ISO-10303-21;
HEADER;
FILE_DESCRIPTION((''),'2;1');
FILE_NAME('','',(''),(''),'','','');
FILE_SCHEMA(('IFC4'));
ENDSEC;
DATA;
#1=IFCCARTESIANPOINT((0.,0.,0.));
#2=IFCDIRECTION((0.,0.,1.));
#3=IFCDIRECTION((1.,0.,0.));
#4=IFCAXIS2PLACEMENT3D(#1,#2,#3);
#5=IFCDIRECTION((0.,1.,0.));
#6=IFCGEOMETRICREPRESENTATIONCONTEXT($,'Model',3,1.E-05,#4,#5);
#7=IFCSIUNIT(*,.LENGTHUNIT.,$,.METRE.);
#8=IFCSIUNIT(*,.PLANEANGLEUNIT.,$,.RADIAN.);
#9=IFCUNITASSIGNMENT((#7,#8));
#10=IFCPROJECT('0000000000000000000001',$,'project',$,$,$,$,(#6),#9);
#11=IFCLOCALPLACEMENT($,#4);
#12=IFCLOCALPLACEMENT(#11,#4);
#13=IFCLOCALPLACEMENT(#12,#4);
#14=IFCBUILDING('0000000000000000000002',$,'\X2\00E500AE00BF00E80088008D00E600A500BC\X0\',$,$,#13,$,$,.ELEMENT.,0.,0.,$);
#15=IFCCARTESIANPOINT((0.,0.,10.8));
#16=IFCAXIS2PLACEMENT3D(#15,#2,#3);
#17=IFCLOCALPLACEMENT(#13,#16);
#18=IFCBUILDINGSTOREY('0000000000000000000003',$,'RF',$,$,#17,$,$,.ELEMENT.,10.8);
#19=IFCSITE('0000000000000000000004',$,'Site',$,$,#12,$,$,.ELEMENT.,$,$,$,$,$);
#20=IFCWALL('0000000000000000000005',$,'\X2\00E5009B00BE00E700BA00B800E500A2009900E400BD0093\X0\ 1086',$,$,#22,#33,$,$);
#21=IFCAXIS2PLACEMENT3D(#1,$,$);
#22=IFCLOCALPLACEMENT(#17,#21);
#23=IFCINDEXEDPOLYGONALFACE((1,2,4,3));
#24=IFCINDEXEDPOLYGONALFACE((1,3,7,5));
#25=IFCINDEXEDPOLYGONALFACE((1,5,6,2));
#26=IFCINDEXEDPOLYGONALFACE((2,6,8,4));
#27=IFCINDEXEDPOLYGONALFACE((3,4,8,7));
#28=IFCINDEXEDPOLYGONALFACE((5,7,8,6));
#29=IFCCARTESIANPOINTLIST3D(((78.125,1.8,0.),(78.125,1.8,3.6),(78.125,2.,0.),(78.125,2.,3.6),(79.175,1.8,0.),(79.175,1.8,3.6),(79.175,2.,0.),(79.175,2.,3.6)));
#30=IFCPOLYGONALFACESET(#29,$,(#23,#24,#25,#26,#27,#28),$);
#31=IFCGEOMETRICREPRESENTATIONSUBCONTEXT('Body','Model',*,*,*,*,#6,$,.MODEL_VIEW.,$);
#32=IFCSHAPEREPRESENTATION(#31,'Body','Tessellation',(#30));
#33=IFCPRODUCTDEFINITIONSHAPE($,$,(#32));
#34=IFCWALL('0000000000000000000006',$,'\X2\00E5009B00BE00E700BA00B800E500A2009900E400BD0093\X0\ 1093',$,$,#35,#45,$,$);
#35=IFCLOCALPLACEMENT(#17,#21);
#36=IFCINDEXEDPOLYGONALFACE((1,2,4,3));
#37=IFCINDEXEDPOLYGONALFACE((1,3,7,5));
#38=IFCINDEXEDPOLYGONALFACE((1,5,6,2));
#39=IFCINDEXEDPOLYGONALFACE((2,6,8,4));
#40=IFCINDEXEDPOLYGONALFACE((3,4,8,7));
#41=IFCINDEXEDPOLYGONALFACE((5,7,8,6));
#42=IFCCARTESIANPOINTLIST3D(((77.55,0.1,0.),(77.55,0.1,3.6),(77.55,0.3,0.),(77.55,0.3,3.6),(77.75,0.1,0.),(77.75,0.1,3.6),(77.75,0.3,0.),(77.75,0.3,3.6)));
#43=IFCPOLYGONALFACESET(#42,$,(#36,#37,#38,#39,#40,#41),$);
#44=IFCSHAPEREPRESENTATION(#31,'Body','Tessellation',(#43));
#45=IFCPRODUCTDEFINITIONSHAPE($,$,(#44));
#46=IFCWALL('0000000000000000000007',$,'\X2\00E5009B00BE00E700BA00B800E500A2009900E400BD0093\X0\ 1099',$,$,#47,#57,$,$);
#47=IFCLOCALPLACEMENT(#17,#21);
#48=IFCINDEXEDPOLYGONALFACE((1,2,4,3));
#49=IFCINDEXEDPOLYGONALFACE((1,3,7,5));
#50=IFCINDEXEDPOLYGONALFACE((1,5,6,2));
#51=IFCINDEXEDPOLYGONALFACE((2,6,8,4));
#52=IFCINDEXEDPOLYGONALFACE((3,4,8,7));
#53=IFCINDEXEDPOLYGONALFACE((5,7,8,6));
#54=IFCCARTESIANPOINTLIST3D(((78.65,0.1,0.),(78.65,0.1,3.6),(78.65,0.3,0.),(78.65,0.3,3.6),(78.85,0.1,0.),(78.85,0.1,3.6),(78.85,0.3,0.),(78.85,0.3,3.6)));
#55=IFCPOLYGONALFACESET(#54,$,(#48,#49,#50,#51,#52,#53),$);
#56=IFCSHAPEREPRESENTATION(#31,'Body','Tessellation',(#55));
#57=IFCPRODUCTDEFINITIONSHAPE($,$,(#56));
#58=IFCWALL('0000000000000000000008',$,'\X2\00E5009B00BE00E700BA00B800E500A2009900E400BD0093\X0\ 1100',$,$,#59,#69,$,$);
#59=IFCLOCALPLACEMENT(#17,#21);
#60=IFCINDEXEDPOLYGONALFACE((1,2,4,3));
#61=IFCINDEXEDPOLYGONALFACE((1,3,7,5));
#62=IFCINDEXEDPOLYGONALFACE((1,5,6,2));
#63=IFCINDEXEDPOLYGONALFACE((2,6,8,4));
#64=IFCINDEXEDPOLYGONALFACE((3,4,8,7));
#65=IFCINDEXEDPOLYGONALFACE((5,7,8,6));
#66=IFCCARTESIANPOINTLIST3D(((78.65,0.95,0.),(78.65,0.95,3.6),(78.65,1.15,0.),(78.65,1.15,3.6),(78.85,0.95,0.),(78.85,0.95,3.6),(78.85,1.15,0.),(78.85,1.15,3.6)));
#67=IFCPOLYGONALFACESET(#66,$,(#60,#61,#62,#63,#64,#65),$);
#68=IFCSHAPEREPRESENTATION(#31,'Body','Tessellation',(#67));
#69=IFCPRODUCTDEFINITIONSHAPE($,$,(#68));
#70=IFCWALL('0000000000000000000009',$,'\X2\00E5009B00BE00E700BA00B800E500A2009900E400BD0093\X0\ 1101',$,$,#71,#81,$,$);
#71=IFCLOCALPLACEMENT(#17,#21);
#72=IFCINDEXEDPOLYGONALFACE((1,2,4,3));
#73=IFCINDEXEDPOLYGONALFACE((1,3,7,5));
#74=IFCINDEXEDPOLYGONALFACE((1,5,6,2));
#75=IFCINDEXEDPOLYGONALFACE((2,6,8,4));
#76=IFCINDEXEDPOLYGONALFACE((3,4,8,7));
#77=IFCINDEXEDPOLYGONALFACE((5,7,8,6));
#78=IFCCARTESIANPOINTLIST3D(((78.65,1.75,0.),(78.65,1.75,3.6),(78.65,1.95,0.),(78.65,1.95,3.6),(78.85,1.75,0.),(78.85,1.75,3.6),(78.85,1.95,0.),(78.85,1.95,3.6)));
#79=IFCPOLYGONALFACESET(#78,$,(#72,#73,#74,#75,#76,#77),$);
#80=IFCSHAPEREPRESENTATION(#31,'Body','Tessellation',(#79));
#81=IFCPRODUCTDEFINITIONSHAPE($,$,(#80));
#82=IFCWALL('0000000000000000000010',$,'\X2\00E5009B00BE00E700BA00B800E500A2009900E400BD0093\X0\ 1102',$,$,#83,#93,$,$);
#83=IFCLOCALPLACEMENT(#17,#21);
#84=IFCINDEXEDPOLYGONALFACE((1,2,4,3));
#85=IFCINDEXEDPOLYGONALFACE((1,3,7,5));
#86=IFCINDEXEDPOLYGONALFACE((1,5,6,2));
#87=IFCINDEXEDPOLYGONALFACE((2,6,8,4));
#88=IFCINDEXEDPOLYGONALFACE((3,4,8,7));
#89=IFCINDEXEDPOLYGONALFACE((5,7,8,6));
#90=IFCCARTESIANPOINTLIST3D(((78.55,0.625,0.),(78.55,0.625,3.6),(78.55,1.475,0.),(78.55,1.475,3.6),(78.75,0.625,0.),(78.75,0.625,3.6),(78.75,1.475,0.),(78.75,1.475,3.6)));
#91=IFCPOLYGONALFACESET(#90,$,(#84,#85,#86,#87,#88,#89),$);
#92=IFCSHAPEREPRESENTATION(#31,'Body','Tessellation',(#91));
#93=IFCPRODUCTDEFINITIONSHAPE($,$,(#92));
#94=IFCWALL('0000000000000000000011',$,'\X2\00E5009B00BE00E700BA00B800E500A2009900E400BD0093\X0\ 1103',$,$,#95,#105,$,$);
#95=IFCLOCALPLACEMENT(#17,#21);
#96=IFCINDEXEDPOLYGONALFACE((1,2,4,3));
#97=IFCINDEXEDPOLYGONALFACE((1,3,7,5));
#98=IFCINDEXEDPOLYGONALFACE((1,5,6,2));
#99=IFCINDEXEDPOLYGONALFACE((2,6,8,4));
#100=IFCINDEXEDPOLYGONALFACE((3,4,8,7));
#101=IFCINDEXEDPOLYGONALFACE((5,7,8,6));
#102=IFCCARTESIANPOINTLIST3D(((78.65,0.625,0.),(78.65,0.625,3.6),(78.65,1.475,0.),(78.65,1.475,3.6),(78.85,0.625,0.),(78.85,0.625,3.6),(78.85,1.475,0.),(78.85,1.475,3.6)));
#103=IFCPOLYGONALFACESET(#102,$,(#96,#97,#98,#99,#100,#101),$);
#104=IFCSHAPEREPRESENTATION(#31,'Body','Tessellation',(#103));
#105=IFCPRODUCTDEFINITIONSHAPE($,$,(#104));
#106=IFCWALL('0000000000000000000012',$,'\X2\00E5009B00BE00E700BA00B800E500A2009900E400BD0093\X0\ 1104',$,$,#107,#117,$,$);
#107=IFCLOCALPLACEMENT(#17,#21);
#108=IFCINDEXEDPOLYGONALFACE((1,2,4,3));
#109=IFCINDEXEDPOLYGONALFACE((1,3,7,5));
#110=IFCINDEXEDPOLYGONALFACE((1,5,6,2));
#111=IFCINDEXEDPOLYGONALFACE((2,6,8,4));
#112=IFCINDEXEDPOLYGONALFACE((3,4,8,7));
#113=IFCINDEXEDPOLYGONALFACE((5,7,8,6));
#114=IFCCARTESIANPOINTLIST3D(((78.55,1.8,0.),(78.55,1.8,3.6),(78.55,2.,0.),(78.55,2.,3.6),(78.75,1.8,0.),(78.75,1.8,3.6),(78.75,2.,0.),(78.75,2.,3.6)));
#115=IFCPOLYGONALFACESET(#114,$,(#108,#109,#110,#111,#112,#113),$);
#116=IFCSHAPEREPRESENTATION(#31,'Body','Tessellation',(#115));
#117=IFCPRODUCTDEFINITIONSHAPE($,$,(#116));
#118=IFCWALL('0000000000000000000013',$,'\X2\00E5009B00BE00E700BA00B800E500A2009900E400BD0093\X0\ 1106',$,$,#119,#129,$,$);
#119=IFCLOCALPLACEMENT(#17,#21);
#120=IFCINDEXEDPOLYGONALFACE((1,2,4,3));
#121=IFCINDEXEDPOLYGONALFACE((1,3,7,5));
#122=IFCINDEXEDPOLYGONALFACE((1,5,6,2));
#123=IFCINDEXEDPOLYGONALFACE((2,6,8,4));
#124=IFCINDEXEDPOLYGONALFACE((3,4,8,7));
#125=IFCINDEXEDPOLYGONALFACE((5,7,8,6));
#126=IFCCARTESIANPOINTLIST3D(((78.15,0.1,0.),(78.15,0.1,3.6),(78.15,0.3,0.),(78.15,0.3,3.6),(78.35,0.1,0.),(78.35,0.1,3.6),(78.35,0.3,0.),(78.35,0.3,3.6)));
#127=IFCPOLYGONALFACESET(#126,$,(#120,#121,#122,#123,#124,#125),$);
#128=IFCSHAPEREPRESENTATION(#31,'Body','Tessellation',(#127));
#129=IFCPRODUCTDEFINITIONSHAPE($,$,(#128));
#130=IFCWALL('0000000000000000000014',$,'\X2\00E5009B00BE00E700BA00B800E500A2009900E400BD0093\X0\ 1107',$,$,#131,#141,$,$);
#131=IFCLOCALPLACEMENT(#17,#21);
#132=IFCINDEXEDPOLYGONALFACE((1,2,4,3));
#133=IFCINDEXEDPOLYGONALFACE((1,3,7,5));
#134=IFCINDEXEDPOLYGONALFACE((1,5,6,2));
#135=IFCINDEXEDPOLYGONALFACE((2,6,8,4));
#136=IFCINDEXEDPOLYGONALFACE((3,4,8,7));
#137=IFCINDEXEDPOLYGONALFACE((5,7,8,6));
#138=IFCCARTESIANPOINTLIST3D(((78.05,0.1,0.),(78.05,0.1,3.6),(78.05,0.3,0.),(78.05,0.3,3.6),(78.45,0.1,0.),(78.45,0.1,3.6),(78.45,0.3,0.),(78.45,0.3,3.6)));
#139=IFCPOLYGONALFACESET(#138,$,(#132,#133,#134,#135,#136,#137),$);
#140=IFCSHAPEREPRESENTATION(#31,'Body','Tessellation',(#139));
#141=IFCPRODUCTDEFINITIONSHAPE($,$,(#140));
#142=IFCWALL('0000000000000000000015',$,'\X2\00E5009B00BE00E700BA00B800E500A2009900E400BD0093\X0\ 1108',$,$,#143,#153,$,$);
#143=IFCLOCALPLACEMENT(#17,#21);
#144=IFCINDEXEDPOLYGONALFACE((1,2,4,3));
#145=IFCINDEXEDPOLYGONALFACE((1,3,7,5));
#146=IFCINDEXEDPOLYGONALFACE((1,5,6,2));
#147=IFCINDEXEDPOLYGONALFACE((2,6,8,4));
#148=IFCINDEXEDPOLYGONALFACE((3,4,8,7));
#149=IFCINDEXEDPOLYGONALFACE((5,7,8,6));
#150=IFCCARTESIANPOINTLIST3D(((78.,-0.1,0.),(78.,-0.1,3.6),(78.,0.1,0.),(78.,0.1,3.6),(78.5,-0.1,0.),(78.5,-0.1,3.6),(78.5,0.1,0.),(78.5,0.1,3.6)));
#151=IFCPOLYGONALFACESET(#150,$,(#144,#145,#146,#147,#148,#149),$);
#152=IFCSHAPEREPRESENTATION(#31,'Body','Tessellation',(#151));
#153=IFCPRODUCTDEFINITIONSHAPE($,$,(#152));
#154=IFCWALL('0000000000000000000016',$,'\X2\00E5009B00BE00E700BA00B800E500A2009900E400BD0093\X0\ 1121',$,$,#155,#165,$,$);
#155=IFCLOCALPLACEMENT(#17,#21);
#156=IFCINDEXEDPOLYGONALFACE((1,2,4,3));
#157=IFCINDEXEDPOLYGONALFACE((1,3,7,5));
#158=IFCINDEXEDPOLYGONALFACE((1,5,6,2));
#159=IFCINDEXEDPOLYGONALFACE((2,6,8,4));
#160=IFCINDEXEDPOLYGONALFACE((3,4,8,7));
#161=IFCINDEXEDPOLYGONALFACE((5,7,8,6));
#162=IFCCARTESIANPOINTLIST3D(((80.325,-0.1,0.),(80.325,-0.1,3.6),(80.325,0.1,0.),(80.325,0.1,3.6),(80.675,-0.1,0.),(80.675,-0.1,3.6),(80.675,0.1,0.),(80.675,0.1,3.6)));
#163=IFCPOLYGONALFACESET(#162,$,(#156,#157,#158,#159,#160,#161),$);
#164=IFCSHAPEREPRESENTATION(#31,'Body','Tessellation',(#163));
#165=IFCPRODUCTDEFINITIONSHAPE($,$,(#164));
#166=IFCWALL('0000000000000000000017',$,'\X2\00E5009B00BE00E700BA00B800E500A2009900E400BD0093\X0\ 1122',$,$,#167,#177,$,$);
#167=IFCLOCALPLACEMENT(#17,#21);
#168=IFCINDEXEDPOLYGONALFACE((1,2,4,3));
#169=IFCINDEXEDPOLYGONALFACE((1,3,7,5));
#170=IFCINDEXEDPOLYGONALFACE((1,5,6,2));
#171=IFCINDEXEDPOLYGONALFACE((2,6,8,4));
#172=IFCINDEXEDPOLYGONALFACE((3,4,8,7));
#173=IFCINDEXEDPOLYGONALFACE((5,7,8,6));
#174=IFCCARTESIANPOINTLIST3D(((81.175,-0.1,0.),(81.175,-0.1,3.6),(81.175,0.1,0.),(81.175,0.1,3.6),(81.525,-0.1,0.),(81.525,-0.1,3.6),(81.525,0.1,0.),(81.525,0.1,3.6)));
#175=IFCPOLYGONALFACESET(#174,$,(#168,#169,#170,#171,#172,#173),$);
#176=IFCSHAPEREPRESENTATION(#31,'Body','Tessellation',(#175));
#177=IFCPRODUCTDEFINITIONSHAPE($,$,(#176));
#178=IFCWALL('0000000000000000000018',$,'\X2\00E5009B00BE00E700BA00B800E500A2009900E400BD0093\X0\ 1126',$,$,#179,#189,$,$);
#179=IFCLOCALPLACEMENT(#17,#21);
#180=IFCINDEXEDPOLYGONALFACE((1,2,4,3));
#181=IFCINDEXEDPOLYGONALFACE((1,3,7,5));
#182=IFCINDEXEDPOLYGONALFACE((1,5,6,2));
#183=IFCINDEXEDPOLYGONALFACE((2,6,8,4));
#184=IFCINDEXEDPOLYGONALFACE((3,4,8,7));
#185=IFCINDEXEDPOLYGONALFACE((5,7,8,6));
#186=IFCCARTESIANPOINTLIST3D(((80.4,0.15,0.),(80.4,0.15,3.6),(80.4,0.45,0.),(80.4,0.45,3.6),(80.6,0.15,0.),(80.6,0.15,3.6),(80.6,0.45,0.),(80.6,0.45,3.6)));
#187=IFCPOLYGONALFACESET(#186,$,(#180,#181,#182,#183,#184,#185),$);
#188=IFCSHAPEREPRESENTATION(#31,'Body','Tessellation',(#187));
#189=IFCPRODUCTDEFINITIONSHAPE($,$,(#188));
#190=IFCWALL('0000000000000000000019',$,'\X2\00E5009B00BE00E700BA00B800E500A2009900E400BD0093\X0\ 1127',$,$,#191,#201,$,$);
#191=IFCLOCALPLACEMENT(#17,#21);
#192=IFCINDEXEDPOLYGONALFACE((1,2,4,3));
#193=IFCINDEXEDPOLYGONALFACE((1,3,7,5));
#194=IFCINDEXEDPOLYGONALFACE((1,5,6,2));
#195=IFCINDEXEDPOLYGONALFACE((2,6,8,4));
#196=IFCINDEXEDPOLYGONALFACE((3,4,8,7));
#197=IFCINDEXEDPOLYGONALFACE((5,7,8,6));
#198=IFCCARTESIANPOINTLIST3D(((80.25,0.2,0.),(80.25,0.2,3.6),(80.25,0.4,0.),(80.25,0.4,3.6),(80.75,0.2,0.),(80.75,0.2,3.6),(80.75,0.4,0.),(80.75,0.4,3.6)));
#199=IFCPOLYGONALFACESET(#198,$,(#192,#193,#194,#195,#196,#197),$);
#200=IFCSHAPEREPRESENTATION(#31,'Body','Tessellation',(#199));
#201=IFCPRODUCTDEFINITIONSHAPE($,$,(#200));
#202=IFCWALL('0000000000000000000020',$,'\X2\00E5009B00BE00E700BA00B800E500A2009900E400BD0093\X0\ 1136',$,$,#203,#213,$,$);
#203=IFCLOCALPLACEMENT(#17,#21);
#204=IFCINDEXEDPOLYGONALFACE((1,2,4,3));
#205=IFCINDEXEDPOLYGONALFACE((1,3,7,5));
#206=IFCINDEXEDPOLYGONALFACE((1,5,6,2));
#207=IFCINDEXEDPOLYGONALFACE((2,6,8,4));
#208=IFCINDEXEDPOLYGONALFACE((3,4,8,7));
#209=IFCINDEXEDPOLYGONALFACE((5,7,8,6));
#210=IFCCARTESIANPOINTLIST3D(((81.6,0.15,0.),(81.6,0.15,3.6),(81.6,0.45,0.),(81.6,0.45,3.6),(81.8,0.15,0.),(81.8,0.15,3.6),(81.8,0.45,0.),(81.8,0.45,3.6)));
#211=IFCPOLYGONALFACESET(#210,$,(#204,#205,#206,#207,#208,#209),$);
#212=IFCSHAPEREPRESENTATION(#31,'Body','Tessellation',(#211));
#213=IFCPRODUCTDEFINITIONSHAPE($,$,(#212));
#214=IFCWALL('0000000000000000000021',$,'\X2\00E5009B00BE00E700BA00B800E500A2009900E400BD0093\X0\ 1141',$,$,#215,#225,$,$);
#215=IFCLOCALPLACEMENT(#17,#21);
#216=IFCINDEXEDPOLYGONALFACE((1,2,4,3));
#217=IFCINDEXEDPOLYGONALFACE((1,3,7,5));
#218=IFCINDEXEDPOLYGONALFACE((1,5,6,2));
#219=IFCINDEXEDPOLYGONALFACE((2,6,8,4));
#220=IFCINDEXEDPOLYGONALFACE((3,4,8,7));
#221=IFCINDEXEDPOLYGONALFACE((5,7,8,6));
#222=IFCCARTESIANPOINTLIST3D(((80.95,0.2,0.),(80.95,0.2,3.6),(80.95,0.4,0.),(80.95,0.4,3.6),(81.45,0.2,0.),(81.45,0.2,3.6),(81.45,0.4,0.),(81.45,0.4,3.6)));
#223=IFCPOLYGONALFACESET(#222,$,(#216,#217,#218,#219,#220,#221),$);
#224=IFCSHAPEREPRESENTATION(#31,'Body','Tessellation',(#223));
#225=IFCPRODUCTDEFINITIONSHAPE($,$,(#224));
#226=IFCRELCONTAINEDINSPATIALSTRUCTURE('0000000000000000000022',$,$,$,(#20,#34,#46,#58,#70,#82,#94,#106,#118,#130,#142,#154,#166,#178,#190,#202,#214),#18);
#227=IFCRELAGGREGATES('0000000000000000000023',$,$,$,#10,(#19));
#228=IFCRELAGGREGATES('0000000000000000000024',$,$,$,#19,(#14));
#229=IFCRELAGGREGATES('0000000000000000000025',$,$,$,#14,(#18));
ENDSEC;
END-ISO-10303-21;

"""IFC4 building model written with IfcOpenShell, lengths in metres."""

from ifc_helpers import new_model, si_unit, direction, frame, frame_2d, origin_with_axes, place, context, subcontext, project, spatial, rectangle, extrude, element, save


model = new_model("IFC4")

# Units and contexts
model_context = context("Model", 3, precision=1e-05, world=origin_with_axes(), true_north=direction((0.0, 1.0, 0.0)))
body_context = subcontext(model_context, "Body", "Model", "MODEL_VIEW")
ifc_project = project(units=[si_unit("LENGTHUNIT", "METRE"), si_unit("PLANEANGLEUNIT", "RADIAN")], contexts=[model_context])

# Site, building, storey
placement = place(None, origin_with_axes())
site_placement = place(placement, origin_with_axes())
site = spatial("IfcSite", under=ifc_project, at=site_placement, Name="Site", CompositionType="ELEMENT")
building_placement = place(site_placement, origin_with_axes())
building = spatial("IfcBuilding", under=site, at=building_placement, Name="å®¿è\u0088\u008dæ¥¼", CompositionType="ELEMENT", ElevationOfRefHeight=0.0, ElevationOfTerrain=0.0)
storey_placement = place(building_placement, frame((0.0, 0.0, 10.8), z_axis=(0.0, 0.0, 1.0), x_axis=(1.0, 0.0, 0.0)))
storey = spatial("IfcBuildingStorey", under=building, at=storey_placement, Name="RF", CompositionType="ELEMENT", Elevation=10.8)

# Walls
wall_1_placement = place(storey_placement, frame((78.65, 1.9, 0.0), z_axis=(0.0, 0.0, 1.0), x_axis=(-1.0, 0.0, 0.0)))
element("IfcWall", 1, at=wall_1_placement, inside=storey, Name="å\u009b¾çº¸å¢\u0099ä½\u0093 1086", context=body_context, shape_type="SweptSolid", body=[
    extrude(rectangle(XDim=1.05, YDim=0.2, at=frame_2d((0.0, 0.0), x_axis=(1.0, 0.0, 0.0))), frame((0.0, 0.0, 0.0), z_axis=(0.0, 0.0, 1.0)), (0.0, 0.0, 1.0), 3.6),
])
for number, where, z_axis, x_axis, name in (
    (2, (77.65, 0.2, 0.0), (0.0, 0.0, 1.0), (0.0, -1.0, 0.0), "å\u009b¾çº¸å¢\u0099ä½\u0093 1093"),
    (3, (78.75, 0.2, 0.0), (0.0, 0.0, 1.0), (0.0, -1.0, 0.0), "å\u009b¾çº¸å¢\u0099ä½\u0093 1099"),
    (4, (78.75, 1.05, 0.0), (0.0, 0.0, 1.0), (-1.0, 0.0, 0.0), "å\u009b¾çº¸å¢\u0099ä½\u0093 1100"),
    (5, (78.75, 1.85, 0.0), (0.0, 0.0, 1.0), (-1.0, 0.0, 0.0), "å\u009b¾çº¸å¢\u0099ä½\u0093 1101"),
):
    element("IfcWall", number, at=place(storey_placement, frame(where, z_axis=z_axis, x_axis=x_axis)), inside=storey, Name=name, context=body_context, shape_type="SweptSolid", body=[
        extrude(rectangle(XDim=0.2, YDim=0.2, at=frame_2d((0.0, 0.0), x_axis=(1.0, 0.0, 0.0))), frame((0.0, 0.0, 0.0), z_axis=(0.0, 0.0, 1.0)), (0.0, 0.0, 1.0), 3.6),
    ])
for number, where, z_axis, x_axis, name in (
    (6, (78.65, 1.05, 0.0), (0.0, 0.0, 1.0), (0.0, -1.0, 0.0), "å\u009b¾çº¸å¢\u0099ä½\u0093 1102"),
    (7, (78.75, 1.05, 0.0), (0.0, 0.0, 1.0), (0.0, -1.0, 0.0), "å\u009b¾çº¸å¢\u0099ä½\u0093 1103"),
):
    element("IfcWall", number, at=place(storey_placement, frame(where, z_axis=z_axis, x_axis=x_axis)), inside=storey, Name=name, context=body_context, shape_type="SweptSolid", body=[
        extrude(rectangle(XDim=0.85, YDim=0.2, at=frame_2d((0.0, 0.0), x_axis=(1.0, 0.0, 0.0))), frame((0.0, 0.0, 0.0), z_axis=(0.0, 0.0, 1.0)), (0.0, 0.0, 1.0), 3.6),
    ])
for number, where, z_axis, x_axis, name in (
    (8, (78.65, 1.9, 0.0), (0.0, 0.0, 1.0), (0.0, -1.0, 0.0), "å\u009b¾çº¸å¢\u0099ä½\u0093 1104"),
    (9, (78.25, 0.2, 0.0), (0.0, 0.0, 1.0), (0.0, -1.0, 0.0), "å\u009b¾çº¸å¢\u0099ä½\u0093 1106"),
):
    element("IfcWall", number, at=place(storey_placement, frame(where, z_axis=z_axis, x_axis=x_axis)), inside=storey, Name=name, context=body_context, shape_type="SweptSolid", body=[
        extrude(rectangle(XDim=0.2, YDim=0.2, at=frame_2d((0.0, 0.0), x_axis=(1.0, 0.0, 0.0))), frame((0.0, 0.0, 0.0), z_axis=(0.0, 0.0, 1.0)), (0.0, 0.0, 1.0), 3.6),
    ])
wall_2_placement = place(storey_placement, frame((78.25, 0.2, 0.0), z_axis=(0.0, 0.0, 1.0), x_axis=(1.0, 0.0, 0.0)))
element("IfcWall", 10, at=wall_2_placement, inside=storey, Name="å\u009b¾çº¸å¢\u0099ä½\u0093 1107", context=body_context, shape_type="SweptSolid", body=[
    extrude(rectangle(XDim=0.4, YDim=0.2, at=frame_2d((0.0, 0.0), x_axis=(1.0, 0.0, 0.0))), frame((0.0, 0.0, 0.0), z_axis=(0.0, 0.0, 1.0)), (0.0, 0.0, 1.0), 3.6),
])
wall_3_placement = place(storey_placement, frame((78.25, 0.0, 0.0), z_axis=(0.0, 0.0, 1.0), x_axis=(1.0, 0.0, 0.0)))
element("IfcWall", 11, at=wall_3_placement, inside=storey, Name="å\u009b¾çº¸å¢\u0099ä½\u0093 1108", context=body_context, shape_type="SweptSolid", body=[
    extrude(rectangle(XDim=0.5, YDim=0.2, at=frame_2d((0.0, 0.0), x_axis=(1.0, 0.0, 0.0))), frame((0.0, 0.0, 0.0), z_axis=(0.0, 0.0, 1.0)), (0.0, 0.0, 1.0), 3.6),
])
for number, where, z_axis, x_axis, name in (
    (12, (80.5, 0.0, 0.0), (0.0, 0.0, 1.0), (1.0, 0.0, 0.0), "å\u009b¾çº¸å¢\u0099ä½\u0093 1121"),
    (13, (81.35, 0.0, 0.0), (0.0, 0.0, 1.0), (1.0, 0.0, 0.0), "å\u009b¾çº¸å¢\u0099ä½\u0093 1122"),
):
    element("IfcWall", number, at=place(storey_placement, frame(where, z_axis=z_axis, x_axis=x_axis)), inside=storey, Name=name, context=body_context, shape_type="SweptSolid", body=[
        extrude(rectangle(XDim=0.35, YDim=0.2, at=frame_2d((0.0, 0.0), x_axis=(1.0, 0.0, 0.0))), frame((0.0, 0.0, 0.0), z_axis=(0.0, 0.0, 1.0)), (0.0, 0.0, 1.0), 3.6),
    ])
wall_4_placement = place(storey_placement, frame((80.5, 0.3, 0.0), z_axis=(0.0, 0.0, 1.0), x_axis=(0.0, -1.0, 0.0)))
element("IfcWall", 14, at=wall_4_placement, inside=storey, Name="å\u009b¾çº¸å¢\u0099ä½\u0093 1126", context=body_context, shape_type="SweptSolid", body=[
    extrude(rectangle(XDim=0.3, YDim=0.2, at=frame_2d((0.0, 0.0), x_axis=(1.0, 0.0, 0.0))), frame((0.0, 0.0, 0.0), z_axis=(0.0, 0.0, 1.0)), (0.0, 0.0, 1.0), 3.6),
])
wall_5_placement = place(storey_placement, frame((80.5, 0.3, 0.0), z_axis=(0.0, 0.0, 1.0), x_axis=(1.0, 0.0, 0.0)))
element("IfcWall", 15, at=wall_5_placement, inside=storey, Name="å\u009b¾çº¸å¢\u0099ä½\u0093 1127", context=body_context, shape_type="SweptSolid", body=[
    extrude(rectangle(XDim=0.5, YDim=0.2, at=frame_2d((0.0, 0.0), x_axis=(1.0, 0.0, 0.0))), frame((0.0, 0.0, 0.0), z_axis=(0.0, 0.0, 1.0)), (0.0, 0.0, 1.0), 3.6),
])
wall_6_placement = place(storey_placement, frame((81.7, 0.3, 0.0), z_axis=(0.0, 0.0, 1.0), x_axis=(0.0, -1.0, 0.0)))
element("IfcWall", 16, at=wall_6_placement, inside=storey, Name="å\u009b¾çº¸å¢\u0099ä½\u0093 1136", context=body_context, shape_type="SweptSolid", body=[
    extrude(rectangle(XDim=0.3, YDim=0.2, at=frame_2d((0.0, 0.0), x_axis=(1.0, 0.0, 0.0))), frame((0.0, 0.0, 0.0), z_axis=(0.0, 0.0, 1.0)), (0.0, 0.0, 1.0), 3.6),
])
for number, where, z_axis, x_axis, name in (
    (17, (81.2, 0.3, 0.0), (0.0, 0.0, 1.0), (1.0, 0.0, 0.0), "å\u009b¾çº¸å¢\u0099ä½\u0093 1141"),
):
    element("IfcWall", number, at=place(storey_placement, frame(where, z_axis=z_axis, x_axis=x_axis)), inside=storey, Name=name, context=body_context, shape_type="SweptSolid", body=[
        extrude(rectangle(XDim=0.5, YDim=0.2, at=frame_2d((0.0, 0.0), x_axis=(1.0, 0.0, 0.0))), frame((0.0, 0.0, 0.0), z_axis=(0.0, 0.0, 1.0)), (0.0, 0.0, 1.0), 3.6),
    ])

save(model, "model.ifc")
